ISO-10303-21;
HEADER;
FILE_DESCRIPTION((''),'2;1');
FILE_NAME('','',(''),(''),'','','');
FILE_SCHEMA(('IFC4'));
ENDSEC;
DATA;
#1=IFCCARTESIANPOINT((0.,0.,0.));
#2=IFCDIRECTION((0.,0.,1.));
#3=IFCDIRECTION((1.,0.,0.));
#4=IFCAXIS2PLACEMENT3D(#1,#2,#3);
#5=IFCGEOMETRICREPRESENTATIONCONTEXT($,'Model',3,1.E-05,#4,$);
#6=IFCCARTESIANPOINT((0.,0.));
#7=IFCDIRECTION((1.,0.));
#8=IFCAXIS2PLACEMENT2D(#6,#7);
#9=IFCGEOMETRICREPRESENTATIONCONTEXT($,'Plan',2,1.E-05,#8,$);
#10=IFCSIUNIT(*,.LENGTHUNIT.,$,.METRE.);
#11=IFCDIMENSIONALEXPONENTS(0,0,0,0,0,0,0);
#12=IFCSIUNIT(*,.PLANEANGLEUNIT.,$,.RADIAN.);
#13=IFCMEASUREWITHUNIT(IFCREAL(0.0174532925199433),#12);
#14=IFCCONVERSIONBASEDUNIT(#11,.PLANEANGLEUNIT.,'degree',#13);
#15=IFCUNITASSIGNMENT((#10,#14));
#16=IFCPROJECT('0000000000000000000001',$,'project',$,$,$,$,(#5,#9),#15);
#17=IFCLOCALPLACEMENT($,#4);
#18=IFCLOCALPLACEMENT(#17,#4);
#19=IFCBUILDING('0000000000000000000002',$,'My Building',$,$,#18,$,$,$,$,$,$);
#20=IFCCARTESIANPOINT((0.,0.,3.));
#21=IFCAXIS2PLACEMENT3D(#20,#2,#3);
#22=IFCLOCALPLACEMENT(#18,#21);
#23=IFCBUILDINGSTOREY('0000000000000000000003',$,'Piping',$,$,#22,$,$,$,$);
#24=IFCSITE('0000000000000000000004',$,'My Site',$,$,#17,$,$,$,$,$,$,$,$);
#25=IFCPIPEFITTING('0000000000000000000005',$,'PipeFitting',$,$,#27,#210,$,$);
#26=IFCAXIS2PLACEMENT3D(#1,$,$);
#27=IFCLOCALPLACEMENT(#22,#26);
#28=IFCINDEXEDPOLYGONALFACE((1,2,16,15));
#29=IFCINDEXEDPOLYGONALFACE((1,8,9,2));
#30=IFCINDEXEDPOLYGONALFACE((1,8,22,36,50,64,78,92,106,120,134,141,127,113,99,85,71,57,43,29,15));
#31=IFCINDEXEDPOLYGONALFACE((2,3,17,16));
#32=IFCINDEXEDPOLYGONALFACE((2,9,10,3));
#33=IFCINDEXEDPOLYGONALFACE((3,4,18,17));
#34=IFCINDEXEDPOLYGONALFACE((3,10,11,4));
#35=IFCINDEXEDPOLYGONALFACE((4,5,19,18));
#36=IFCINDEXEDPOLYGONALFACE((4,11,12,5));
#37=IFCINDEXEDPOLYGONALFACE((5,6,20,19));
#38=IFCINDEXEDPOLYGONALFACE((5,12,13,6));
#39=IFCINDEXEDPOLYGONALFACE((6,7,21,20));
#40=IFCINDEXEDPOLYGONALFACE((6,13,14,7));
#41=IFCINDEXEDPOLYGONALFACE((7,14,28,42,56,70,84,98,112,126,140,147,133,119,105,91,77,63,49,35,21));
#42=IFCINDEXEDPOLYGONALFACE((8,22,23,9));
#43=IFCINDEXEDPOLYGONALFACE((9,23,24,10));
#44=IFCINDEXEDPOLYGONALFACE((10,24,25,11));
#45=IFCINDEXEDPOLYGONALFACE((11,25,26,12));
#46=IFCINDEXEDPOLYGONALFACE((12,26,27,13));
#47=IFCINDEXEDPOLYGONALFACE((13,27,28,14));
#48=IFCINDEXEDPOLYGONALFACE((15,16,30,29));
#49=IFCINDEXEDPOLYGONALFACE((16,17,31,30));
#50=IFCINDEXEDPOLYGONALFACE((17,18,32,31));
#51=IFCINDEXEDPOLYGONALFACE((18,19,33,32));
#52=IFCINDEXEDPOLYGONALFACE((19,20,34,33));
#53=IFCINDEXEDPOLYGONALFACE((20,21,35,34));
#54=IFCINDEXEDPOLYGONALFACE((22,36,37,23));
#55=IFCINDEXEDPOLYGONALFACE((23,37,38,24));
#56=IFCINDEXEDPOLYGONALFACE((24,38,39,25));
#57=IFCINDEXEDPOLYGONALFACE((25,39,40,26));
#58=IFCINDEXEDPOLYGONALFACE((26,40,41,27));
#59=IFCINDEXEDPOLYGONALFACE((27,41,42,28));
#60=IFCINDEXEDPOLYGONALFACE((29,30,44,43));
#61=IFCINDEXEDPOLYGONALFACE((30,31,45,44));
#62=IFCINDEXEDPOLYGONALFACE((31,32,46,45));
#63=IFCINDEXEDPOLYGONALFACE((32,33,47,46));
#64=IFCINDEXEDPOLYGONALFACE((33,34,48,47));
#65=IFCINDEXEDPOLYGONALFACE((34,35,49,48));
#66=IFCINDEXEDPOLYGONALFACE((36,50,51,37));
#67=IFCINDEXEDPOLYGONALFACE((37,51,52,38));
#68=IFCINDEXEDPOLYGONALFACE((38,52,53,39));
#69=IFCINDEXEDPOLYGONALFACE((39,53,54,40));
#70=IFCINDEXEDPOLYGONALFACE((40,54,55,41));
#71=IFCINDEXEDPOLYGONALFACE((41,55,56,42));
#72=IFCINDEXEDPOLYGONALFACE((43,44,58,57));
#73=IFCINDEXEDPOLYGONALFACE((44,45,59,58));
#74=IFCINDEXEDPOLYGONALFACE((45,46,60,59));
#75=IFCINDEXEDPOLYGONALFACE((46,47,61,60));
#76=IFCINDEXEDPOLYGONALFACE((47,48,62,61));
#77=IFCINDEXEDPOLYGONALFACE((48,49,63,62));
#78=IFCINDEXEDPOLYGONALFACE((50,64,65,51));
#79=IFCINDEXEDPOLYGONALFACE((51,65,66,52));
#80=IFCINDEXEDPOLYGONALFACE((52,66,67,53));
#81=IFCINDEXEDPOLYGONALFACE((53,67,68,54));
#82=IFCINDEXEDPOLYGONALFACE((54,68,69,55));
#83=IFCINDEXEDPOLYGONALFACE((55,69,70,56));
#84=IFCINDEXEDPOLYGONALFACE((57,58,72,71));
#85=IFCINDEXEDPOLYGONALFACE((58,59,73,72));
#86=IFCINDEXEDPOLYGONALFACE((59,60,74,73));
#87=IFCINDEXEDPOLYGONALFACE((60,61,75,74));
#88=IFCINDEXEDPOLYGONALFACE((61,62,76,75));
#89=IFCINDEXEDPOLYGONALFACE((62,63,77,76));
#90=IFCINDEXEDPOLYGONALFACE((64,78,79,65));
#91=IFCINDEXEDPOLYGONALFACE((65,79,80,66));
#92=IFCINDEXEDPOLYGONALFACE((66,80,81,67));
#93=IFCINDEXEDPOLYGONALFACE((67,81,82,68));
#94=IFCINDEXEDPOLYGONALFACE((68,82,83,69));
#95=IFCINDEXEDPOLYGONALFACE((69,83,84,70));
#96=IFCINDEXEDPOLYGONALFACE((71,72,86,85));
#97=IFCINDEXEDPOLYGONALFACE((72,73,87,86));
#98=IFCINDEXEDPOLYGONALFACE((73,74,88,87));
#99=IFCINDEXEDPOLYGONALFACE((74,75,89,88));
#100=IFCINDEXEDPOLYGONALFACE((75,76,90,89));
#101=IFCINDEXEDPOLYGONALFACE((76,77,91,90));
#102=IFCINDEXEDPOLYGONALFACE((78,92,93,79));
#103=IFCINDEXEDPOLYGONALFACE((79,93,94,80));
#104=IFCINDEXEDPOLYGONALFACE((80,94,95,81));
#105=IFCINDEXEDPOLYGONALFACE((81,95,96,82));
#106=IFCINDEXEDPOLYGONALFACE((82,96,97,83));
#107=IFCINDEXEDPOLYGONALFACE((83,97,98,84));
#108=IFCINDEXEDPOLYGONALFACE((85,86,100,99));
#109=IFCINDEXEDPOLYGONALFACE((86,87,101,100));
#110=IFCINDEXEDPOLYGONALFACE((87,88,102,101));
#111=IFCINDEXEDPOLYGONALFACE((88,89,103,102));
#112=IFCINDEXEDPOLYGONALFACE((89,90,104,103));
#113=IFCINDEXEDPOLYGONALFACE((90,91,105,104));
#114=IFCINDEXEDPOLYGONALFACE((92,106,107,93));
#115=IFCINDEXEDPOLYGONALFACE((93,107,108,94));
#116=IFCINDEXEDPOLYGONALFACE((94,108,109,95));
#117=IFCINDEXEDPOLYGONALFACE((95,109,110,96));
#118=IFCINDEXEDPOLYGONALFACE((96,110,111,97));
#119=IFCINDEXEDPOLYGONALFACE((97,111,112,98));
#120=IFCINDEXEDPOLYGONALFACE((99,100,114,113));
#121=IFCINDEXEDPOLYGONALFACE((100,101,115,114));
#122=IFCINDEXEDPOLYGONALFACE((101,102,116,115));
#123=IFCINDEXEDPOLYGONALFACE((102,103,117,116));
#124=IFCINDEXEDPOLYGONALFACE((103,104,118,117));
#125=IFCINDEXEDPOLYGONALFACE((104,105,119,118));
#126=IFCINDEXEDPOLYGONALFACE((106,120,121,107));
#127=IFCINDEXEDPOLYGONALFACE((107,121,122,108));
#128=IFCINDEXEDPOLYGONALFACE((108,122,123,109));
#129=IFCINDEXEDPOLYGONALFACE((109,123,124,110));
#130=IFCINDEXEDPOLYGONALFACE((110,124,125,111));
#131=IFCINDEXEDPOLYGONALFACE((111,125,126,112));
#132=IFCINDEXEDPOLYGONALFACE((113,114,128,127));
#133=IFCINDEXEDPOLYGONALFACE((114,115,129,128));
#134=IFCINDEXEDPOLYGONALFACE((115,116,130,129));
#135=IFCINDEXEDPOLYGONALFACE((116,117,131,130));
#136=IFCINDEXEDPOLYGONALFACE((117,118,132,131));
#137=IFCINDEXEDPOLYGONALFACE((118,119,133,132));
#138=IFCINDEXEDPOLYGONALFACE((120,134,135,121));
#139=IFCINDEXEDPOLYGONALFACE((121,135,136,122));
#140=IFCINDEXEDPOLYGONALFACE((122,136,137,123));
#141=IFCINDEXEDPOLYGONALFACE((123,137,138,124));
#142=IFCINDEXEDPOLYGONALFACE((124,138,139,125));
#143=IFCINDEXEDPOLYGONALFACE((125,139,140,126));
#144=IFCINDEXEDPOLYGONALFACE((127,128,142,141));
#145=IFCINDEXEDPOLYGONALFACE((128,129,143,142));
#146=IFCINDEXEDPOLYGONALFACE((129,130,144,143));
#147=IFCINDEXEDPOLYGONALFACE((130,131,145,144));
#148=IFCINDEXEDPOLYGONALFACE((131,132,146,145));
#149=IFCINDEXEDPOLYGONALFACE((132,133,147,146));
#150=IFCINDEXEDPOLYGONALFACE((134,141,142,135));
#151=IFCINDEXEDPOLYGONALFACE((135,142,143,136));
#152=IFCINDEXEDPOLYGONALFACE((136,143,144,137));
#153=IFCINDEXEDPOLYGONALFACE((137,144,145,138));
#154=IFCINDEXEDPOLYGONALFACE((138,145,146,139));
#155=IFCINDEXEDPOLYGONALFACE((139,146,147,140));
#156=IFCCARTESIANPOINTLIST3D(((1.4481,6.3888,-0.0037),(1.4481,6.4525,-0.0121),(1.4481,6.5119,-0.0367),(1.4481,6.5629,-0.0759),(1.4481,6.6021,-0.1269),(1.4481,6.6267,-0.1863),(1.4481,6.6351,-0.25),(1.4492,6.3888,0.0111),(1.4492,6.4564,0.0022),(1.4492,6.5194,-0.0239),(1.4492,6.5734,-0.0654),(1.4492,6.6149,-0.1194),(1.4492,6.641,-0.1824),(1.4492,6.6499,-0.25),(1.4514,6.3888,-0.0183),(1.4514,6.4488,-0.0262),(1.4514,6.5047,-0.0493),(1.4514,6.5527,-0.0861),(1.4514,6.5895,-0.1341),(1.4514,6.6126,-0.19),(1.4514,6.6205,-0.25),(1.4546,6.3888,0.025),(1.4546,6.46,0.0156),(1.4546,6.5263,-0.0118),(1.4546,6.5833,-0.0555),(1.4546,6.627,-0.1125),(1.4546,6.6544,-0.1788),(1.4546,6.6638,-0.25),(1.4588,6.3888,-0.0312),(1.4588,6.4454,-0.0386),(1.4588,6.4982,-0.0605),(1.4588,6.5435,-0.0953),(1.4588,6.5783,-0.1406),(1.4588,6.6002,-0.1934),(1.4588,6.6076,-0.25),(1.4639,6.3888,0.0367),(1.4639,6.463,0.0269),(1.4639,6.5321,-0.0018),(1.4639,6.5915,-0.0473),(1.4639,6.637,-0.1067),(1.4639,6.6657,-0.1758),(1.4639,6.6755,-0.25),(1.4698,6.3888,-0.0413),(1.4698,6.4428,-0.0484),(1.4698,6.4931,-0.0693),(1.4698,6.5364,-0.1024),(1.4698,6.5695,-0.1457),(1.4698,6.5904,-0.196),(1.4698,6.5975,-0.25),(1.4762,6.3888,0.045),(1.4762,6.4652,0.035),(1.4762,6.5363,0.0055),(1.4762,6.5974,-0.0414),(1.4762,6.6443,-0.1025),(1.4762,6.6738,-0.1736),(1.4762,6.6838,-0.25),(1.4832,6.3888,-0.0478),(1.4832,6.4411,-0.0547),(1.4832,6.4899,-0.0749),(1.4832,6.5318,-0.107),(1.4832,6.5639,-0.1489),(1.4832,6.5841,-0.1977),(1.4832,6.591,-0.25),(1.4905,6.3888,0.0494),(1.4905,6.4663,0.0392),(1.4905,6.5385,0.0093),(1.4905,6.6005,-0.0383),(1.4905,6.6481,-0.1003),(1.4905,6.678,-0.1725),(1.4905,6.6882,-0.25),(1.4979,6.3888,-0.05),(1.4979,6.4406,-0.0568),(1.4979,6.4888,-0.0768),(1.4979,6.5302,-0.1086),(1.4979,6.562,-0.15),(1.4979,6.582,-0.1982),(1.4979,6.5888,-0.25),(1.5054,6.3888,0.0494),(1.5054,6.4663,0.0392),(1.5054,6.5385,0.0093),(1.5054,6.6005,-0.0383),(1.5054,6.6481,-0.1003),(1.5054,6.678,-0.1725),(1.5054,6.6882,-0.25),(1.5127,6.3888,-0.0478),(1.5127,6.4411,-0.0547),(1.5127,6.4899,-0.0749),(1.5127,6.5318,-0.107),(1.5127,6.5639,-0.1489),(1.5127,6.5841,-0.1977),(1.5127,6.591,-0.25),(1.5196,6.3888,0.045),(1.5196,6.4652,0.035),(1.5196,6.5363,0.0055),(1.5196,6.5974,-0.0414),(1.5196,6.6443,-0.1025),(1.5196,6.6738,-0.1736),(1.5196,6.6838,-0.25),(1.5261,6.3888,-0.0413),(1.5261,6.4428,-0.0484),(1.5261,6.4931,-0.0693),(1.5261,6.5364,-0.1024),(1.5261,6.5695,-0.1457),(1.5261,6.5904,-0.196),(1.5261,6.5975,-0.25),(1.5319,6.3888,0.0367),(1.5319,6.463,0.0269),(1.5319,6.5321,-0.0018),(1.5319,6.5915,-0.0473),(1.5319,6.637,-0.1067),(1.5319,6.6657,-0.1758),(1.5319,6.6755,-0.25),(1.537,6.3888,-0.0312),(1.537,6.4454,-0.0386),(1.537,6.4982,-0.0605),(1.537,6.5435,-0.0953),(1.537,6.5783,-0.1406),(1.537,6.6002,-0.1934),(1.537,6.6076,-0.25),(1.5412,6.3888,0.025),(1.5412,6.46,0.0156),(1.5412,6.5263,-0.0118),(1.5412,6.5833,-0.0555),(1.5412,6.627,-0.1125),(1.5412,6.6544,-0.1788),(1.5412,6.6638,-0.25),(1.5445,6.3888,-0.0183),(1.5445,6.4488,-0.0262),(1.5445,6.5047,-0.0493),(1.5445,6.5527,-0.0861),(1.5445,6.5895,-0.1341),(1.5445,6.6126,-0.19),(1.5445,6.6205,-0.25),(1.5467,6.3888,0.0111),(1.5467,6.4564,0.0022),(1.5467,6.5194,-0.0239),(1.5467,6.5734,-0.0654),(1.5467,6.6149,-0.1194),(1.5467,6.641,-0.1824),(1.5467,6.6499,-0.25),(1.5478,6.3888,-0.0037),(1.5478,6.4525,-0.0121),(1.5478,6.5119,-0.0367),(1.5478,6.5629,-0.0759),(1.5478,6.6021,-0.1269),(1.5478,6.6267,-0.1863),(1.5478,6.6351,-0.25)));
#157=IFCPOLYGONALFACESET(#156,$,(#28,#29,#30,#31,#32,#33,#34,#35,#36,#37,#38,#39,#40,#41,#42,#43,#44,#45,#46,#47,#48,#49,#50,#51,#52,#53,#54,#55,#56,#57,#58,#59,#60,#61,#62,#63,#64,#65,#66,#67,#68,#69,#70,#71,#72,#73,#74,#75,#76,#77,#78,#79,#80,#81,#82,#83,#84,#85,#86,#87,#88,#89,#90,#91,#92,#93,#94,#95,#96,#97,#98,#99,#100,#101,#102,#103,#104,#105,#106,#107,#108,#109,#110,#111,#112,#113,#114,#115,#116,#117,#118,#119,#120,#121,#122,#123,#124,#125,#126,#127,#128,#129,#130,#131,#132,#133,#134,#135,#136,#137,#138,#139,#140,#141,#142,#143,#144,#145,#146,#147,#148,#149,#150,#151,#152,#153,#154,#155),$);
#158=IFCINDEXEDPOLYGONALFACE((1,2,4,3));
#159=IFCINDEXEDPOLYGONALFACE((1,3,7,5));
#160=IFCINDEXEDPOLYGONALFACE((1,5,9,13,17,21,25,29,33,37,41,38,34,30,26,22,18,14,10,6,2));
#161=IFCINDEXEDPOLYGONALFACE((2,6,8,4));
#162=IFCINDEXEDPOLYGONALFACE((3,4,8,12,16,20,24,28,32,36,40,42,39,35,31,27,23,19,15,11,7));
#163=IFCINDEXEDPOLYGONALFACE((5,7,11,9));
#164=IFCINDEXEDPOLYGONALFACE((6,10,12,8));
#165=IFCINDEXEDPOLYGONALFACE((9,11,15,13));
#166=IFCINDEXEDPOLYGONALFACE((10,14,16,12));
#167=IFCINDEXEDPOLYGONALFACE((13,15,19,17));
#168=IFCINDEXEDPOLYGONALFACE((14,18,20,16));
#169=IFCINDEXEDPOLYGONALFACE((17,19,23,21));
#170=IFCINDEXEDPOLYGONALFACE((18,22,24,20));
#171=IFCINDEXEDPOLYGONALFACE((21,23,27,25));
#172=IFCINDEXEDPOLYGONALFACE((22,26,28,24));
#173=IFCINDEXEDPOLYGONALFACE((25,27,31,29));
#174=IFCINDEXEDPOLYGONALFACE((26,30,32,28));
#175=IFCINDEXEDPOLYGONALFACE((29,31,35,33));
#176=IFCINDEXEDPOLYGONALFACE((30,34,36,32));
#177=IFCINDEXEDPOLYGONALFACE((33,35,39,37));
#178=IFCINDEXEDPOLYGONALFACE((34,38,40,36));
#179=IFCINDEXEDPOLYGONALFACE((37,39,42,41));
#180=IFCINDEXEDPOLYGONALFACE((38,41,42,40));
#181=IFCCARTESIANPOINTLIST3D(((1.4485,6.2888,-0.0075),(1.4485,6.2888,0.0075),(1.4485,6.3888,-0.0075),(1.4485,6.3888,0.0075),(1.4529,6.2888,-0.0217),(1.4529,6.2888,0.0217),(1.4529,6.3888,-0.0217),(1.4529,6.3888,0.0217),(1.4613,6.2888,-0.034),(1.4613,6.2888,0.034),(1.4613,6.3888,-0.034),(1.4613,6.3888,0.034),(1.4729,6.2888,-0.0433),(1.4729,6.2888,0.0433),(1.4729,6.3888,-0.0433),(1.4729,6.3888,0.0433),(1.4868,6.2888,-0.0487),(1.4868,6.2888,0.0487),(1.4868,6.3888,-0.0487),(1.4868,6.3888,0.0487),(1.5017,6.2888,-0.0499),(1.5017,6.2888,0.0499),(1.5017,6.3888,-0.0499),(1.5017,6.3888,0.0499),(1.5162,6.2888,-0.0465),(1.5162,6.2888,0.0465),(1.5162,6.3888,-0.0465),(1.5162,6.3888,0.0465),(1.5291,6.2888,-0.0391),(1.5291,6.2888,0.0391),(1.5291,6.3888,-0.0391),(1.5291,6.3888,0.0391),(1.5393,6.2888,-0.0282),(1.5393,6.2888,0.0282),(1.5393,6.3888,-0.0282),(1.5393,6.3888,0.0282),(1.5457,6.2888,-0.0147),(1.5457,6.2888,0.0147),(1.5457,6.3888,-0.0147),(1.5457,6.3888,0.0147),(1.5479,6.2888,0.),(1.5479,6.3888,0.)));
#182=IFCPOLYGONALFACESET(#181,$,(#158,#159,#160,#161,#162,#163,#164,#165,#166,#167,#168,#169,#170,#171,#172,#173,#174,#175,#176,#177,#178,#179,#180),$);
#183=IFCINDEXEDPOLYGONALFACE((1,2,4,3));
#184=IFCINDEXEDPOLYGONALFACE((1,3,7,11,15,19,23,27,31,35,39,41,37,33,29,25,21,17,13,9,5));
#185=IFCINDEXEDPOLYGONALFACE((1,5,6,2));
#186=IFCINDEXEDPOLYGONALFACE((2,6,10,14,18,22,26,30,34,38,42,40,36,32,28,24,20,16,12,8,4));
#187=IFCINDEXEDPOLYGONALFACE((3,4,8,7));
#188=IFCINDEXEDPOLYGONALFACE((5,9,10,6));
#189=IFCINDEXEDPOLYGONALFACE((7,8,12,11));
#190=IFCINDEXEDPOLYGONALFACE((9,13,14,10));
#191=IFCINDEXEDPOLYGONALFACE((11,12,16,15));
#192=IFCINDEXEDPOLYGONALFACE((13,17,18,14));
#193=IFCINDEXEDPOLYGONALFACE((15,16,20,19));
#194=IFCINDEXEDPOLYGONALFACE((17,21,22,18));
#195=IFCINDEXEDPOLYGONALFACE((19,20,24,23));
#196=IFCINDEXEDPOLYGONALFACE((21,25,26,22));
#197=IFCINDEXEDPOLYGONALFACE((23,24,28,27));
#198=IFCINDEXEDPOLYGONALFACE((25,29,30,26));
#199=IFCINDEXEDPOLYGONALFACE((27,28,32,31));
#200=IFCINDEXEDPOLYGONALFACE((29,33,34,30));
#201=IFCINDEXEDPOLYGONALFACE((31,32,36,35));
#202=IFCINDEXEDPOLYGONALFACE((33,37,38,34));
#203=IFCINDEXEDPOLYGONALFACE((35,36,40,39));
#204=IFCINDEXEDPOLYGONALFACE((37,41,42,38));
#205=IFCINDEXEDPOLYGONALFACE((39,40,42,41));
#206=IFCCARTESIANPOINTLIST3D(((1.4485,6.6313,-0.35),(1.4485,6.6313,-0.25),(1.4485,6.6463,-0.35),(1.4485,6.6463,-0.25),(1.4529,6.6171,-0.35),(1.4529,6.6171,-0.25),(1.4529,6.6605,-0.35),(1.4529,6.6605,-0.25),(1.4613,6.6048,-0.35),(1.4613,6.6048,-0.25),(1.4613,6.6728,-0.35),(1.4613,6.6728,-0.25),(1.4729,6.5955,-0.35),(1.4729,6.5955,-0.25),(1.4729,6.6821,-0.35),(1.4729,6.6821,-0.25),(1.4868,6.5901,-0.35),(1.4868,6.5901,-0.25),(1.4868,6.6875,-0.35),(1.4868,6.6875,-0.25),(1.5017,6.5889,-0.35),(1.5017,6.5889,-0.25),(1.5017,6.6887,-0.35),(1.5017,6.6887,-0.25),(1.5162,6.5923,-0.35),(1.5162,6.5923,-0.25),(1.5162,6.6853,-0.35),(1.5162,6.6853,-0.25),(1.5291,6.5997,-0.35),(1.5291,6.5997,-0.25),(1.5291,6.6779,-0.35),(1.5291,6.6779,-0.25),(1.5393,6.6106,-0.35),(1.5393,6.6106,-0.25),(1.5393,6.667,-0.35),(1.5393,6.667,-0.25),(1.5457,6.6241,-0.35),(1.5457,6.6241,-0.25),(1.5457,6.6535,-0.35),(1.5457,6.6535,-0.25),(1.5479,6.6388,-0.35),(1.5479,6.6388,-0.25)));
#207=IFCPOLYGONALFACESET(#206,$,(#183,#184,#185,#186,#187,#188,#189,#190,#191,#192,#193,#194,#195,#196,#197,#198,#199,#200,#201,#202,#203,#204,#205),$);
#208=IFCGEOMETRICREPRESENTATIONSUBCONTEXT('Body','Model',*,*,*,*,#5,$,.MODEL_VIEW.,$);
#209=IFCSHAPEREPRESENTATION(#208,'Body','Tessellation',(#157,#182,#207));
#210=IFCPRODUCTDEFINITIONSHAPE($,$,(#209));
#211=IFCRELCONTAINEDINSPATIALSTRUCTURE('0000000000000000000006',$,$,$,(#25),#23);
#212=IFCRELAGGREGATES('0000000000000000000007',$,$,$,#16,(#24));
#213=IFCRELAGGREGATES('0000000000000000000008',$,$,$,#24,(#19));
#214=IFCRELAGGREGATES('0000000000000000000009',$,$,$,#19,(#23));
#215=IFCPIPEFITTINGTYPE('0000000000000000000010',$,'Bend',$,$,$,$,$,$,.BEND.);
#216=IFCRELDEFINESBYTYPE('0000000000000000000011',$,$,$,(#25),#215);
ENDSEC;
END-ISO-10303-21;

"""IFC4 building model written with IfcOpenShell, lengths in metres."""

from ifc_helpers import new_model, entity, si_unit, converted_unit, frame, origin_with_axes, origin_2d_with_axis, place, context, subcontext, project, spatial, circle, extrude, source, transform, mapped, type_object, type_shapes, element, save


model = new_model("IFC4")

# Units and contexts
model_context = context("Model", 3, precision=1e-05, world=origin_with_axes())
plan_context = context("Plan", 2, precision=1e-05, world=origin_2d_with_axis())
body_context = subcontext(model_context, "Body", "Model", "MODEL_VIEW")
ifc_project = project(units=[si_unit("LENGTHUNIT", "METRE"), converted_unit("PLANEANGLEUNIT", "degree", entity("IfcReal", 0.0174532925199433), si_unit("PLANEANGLEUNIT", "RADIAN"), dimensions=[0, 0, 0, 0, 0, 0, 0])], contexts=[model_context, plan_context])

# Site, building, storey
site_placement = place(None, origin_with_axes())
site = spatial("IfcSite", under=ifc_project, at=site_placement, Name="My Site")
building_placement = place(site_placement, origin_with_axes())
building = spatial("IfcBuilding", under=site, at=building_placement, Name="My Building")
storey_placement = place(building_placement, frame((0.0, 0.0, 3.0), z_axis=(0.0, 0.0, 1.0), x_axis=(1.0, 0.0, 0.0)))
storey = spatial("IfcBuildingStorey", under=building, at=storey_placement, Name="Piping")

# Pipe fitting
pipe_fitting_type = type_object("IfcPipeFittingType", Name="Bend", PredefinedType="BEND")
shared_shape = source(origin_with_axes(), body_context, "Body", "SolidModel", [
    entity("IfcSweptDiskSolid", entity("IfcIndexedPolyCurve", entity("IfcCartesianPointList3D", [[0.0, 0.0, -0.1], [0.0, -0.0732, -0.2768], [0.0, -0.25, -0.35]]), [entity("IfcArcIndex", [1, 2, 3])]), 0.05),
    extrude(circle(Radius=0.05), origin_with_axes(), (0.0, 0.0, -1.0), 0.1),
    extrude(circle(Radius=0.05), frame((0.0, -0.25, -0.35), z_axis=(0.0, -1.0, 0.0), x_axis=(1.0, 0.0, 0.0)), (0.0, 0.0, 1.0), 0.1),
])
type_shapes(pipe_fitting_type, [shared_shape])
for number, where, z_axis, x_axis, name in (
    (1, (1.4979, 6.2888, 0.0), (0.0, -1.0, 0.0), (1.0, 0.0, 0.0), "PipeFitting"),
):
    element("IfcPipeFitting", number, at=place(storey_placement, frame(where, z_axis=z_axis, x_axis=x_axis)), inside=storey, type_object=pipe_fitting_type, Name=name, context=body_context, shape_type="MappedRepresentation", body=[
        mapped(shared_shape, transform((0.0, 0.0, 0.0), x_axis=(1.0, 0.0, 0.0), y_axis=(0.0, 1.0, 0.0), z_axis=(0.0, 0.0, 1.0), scale=1.0)),
    ])

save(model, "model.ifc")
